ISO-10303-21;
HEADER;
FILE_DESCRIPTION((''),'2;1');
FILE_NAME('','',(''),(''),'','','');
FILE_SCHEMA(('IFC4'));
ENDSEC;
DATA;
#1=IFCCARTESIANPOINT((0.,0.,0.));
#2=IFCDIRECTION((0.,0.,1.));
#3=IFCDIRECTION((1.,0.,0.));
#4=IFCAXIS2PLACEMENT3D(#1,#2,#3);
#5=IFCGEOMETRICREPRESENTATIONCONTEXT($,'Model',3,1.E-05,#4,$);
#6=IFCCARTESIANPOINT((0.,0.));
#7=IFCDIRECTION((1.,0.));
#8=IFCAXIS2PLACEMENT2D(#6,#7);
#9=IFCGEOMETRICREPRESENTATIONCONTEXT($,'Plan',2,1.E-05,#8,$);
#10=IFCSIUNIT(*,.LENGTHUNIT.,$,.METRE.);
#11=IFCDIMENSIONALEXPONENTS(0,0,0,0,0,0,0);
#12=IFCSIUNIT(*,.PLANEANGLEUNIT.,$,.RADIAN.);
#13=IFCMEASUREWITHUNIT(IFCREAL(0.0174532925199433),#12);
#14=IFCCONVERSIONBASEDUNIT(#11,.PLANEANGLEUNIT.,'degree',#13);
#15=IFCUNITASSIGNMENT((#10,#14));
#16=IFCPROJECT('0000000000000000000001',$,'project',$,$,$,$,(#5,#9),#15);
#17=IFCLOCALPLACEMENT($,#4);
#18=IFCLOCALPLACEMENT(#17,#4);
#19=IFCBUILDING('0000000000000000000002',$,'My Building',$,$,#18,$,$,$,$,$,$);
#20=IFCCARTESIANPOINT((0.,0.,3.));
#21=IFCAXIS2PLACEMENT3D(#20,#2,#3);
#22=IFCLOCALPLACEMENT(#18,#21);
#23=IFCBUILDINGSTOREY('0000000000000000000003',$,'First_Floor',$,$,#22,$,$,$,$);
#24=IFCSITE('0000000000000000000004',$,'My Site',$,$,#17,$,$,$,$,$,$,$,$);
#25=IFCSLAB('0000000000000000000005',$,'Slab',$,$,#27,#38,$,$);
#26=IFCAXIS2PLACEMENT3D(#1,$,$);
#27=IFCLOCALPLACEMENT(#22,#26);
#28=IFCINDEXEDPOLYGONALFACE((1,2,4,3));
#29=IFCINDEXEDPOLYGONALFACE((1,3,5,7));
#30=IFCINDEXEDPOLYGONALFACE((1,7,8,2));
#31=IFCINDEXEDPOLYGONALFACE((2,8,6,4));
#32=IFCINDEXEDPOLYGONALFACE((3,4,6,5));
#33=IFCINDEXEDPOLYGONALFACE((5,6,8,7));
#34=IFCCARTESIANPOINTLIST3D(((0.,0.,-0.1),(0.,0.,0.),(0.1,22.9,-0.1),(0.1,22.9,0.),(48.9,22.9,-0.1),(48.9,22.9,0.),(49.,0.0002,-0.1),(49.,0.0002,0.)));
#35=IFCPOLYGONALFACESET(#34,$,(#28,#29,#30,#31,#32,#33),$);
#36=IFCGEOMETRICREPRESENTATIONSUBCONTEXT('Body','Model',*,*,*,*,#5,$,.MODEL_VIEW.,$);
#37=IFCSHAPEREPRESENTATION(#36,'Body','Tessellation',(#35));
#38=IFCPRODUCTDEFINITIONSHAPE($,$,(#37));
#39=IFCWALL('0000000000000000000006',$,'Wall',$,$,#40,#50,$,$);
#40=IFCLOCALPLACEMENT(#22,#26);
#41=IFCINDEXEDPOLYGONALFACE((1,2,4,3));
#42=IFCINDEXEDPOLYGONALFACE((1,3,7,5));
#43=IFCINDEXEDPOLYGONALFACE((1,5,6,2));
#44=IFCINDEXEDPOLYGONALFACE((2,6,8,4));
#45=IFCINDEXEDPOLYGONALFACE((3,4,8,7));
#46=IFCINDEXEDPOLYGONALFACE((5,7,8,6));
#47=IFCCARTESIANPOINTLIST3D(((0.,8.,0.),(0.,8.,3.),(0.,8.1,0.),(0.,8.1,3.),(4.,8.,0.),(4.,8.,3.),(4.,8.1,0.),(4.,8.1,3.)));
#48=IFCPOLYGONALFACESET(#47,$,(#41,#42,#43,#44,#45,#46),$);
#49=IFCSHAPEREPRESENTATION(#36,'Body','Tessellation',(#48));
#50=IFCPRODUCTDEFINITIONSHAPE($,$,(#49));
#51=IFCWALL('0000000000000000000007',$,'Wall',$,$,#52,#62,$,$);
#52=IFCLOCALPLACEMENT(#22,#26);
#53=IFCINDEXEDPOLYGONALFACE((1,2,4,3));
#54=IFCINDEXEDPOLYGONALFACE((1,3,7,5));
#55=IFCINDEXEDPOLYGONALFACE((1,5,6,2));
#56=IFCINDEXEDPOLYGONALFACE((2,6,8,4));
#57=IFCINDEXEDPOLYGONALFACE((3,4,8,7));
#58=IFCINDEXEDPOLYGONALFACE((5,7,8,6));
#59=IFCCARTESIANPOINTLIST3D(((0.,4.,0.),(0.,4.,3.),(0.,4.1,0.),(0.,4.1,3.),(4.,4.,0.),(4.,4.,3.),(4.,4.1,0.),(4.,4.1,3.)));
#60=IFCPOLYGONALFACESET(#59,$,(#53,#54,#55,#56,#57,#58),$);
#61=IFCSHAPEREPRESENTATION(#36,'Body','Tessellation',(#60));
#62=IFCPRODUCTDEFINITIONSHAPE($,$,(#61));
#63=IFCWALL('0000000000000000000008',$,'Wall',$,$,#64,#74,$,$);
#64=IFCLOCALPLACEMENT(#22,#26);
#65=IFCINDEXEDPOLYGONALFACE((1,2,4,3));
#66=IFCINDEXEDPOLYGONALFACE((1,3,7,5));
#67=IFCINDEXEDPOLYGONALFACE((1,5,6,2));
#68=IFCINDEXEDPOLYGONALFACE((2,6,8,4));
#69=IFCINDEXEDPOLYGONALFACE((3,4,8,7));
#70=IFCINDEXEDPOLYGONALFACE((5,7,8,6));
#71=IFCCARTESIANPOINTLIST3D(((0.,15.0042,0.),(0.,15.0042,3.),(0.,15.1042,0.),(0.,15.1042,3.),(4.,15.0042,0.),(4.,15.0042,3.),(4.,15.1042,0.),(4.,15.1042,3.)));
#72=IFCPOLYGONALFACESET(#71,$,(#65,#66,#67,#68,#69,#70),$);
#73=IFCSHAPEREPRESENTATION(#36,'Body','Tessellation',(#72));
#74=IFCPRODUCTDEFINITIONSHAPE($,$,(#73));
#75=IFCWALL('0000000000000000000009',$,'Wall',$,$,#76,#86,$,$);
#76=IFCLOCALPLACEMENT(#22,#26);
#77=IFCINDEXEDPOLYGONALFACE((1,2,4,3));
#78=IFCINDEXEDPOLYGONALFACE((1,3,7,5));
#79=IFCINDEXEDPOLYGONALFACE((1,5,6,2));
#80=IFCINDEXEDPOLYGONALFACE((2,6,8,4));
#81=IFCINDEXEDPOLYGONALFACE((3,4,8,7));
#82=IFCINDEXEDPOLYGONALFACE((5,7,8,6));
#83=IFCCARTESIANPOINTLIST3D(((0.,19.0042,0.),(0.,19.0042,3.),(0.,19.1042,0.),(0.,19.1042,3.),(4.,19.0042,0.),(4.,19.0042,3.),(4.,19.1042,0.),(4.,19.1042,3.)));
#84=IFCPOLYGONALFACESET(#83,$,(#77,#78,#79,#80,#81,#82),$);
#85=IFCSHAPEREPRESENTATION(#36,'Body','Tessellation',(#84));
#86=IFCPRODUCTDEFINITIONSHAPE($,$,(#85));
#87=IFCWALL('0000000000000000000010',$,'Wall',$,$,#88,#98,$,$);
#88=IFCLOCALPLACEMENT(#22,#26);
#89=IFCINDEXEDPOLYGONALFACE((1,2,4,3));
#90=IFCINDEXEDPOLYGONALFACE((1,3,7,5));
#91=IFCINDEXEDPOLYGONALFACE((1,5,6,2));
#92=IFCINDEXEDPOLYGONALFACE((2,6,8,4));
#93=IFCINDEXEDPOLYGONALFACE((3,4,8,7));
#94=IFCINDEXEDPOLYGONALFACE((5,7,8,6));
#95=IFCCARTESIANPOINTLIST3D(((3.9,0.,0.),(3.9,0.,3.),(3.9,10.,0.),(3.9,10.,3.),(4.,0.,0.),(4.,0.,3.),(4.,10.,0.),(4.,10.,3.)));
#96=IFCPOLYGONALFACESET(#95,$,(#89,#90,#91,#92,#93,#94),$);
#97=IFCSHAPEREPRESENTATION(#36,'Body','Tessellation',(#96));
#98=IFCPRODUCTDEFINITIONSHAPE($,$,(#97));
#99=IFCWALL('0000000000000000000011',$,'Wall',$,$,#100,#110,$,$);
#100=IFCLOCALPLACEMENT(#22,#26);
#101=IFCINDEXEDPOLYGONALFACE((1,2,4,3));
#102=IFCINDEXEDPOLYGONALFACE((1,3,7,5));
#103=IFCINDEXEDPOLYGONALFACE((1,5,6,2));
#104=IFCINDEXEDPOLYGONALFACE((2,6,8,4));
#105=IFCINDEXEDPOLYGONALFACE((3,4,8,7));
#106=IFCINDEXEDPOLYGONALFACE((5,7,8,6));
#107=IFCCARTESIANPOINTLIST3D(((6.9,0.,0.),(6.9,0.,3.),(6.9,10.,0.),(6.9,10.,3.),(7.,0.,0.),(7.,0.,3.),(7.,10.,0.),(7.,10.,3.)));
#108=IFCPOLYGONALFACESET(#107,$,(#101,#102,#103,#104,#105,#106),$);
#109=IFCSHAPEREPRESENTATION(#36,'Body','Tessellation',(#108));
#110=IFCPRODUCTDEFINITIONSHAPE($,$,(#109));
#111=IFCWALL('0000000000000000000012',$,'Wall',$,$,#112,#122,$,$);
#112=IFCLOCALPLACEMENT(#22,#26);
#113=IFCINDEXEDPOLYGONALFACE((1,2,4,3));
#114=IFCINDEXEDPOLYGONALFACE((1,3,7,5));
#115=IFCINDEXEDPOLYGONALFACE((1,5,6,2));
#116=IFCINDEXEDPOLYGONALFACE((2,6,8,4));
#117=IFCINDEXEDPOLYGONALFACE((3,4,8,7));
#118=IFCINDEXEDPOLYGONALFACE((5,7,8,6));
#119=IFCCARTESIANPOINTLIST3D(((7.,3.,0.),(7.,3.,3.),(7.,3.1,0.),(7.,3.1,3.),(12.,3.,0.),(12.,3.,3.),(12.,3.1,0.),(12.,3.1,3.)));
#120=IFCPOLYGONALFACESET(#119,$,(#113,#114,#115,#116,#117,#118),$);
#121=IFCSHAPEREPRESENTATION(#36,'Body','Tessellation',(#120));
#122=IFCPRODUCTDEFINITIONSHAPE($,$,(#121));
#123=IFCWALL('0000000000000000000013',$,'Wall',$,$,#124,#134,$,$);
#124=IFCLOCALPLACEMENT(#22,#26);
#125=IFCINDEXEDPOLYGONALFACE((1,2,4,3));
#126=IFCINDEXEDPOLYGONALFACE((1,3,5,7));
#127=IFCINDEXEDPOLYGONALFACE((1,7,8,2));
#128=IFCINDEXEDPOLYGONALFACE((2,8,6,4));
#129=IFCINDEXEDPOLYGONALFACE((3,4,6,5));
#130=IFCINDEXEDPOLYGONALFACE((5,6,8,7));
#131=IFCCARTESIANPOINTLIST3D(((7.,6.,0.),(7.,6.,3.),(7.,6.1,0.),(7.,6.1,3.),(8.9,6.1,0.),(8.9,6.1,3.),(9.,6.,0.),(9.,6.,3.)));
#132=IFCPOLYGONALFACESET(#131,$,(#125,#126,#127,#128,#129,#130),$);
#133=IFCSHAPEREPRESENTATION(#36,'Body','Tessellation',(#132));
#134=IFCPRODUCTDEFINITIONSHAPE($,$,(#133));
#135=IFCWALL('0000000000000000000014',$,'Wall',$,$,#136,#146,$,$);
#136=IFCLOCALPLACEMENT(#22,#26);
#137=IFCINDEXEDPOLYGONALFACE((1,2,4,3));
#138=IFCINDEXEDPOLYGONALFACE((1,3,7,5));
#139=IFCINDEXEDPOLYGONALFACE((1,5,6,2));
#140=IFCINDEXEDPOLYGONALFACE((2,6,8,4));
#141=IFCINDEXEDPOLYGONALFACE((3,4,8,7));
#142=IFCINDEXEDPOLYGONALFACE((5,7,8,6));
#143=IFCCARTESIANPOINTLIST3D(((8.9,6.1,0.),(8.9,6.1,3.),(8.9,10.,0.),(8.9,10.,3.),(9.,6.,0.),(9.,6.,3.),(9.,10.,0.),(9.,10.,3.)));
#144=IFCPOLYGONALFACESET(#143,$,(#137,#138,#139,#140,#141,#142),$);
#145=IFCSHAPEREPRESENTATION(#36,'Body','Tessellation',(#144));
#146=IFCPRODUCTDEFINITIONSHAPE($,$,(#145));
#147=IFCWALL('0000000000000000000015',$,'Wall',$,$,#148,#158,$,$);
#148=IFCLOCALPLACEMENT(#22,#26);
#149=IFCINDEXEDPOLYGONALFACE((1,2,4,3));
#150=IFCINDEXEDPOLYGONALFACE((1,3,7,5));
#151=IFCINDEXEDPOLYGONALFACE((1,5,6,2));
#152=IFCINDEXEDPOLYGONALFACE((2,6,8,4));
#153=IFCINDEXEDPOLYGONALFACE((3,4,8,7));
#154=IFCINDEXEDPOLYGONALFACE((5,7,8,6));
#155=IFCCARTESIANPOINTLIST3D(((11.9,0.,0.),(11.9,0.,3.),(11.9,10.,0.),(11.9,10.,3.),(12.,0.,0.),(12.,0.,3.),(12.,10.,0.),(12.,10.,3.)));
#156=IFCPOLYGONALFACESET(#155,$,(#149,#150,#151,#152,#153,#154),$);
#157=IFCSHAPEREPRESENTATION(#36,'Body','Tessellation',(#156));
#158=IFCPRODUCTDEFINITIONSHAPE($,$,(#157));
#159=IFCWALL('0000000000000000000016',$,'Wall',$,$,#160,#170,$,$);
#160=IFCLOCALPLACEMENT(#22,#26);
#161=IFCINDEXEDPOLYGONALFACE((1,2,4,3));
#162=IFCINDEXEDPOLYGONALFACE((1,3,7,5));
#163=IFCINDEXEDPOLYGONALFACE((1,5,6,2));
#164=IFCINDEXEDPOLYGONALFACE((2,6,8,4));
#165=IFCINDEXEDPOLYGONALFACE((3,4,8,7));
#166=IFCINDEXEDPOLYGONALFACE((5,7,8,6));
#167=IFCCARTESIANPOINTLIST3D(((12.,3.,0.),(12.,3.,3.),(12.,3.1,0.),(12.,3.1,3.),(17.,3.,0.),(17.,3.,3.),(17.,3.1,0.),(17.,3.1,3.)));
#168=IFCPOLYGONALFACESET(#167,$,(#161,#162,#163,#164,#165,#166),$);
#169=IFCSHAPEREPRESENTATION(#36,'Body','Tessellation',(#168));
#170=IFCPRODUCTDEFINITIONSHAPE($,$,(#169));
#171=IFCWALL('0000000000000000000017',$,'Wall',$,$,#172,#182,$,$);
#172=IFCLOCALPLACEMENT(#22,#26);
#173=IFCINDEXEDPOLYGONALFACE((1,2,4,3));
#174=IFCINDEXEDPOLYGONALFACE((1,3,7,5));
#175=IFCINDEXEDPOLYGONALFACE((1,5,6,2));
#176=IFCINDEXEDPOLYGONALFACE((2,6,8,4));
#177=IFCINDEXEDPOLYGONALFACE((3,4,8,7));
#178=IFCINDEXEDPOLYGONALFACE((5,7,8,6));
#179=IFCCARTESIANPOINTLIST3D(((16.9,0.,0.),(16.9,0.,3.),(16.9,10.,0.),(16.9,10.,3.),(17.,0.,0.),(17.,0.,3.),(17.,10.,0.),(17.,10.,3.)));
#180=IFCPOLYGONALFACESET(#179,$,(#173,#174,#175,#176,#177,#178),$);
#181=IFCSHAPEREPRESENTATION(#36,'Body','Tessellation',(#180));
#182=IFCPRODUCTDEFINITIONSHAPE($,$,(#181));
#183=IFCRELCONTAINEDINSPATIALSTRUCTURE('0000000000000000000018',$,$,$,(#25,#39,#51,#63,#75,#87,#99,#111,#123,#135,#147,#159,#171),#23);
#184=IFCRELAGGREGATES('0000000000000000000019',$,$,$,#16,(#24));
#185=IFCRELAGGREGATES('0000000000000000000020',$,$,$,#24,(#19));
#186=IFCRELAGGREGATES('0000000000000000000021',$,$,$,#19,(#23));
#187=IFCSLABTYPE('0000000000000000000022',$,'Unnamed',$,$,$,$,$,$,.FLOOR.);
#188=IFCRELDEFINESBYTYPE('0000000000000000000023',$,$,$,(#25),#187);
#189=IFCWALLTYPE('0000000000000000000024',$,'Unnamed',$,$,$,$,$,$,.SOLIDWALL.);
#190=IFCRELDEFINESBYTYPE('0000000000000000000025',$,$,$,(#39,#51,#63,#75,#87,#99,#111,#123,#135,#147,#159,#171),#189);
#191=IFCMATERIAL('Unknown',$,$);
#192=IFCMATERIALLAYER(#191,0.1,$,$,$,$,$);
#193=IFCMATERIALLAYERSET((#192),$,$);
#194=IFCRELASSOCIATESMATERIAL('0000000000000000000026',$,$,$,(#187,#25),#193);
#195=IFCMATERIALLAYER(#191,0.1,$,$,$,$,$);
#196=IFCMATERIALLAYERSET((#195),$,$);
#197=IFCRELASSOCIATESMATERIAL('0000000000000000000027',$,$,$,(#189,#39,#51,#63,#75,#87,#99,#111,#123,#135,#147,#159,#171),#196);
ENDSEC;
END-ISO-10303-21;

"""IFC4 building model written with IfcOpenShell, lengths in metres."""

from ifc_helpers import new_model, entity, si_unit, converted_unit, frame, origin_with_axes, origin_2d_with_axis, place, context, subcontext, project, spatial, line, indexed_curve, outline, extrude, material, layer, layer_set, layer_usage, type_object, element, save


model = new_model("IFC4")

# Units and contexts
model_context = context("Model", 3, precision=1e-05, world=origin_with_axes())
plan_context = context("Plan", 2, precision=1e-05, world=origin_2d_with_axis())
body_context = subcontext(model_context, "Body", "Model", "MODEL_VIEW")
ifc_project = project(units=[si_unit("LENGTHUNIT", "METRE"), converted_unit("PLANEANGLEUNIT", "degree", entity("IfcReal", 0.0174532925199433), si_unit("PLANEANGLEUNIT", "RADIAN"), dimensions=[0, 0, 0, 0, 0, 0, 0])], contexts=[model_context, plan_context])

# Site, building, storey
site_placement = place(None, origin_with_axes())
site = spatial("IfcSite", under=ifc_project, at=site_placement, Name="My Site")
building_placement = place(site_placement, origin_with_axes())
building = spatial("IfcBuilding", under=site, at=building_placement, Name="My Building")
storey_placement = place(building_placement, frame((0.0, 0.0, 3.0), z_axis=(0.0, 0.0, 1.0), x_axis=(1.0, 0.0, 0.0)))
storey = spatial("IfcBuildingStorey", under=building, at=storey_placement, Name="First_Floor")

# Slab
ifc_material = material(Name="Unknown")
ifc_layer_1 = layer(ifc_material, 0.1)
ifc_layer_set_1 = layer_set([ifc_layer_1])
ifc_layer_usage_1 = layer_usage(ifc_layer_set_1, "AXIS3", "POSITIVE", -0.1)
slab_type = type_object("IfcSlabType", Name="Unnamed", PredefinedType="FLOOR", material=ifc_layer_set_1)
slab_placement = place(storey_placement, frame((0.1, 22.9, 0.0), z_axis=(0.0, 0.0, 1.0), x_axis=(1.0, 0.0, 0.0)))
element("IfcSlab", 1, at=slab_placement, inside=storey, type_object=slab_type, material=ifc_layer_usage_1, Name="Slab", context=body_context, shape_type="SweptSolid", body=[
    extrude(outline(indexed_curve([(0.0, 0.0), (48.8, 0.0), (48.9, -22.8998), (-0.1, -22.9), (0.0, 0.0)])), frame((0.0, 0.0, -0.1), z_axis=(0.0, 0.0, 1.0), x_axis=(1.0, 0.0, 0.0)), (0.0, 0.0, 1.0), 0.1),
])

# Walls
ifc_layer_2 = layer(ifc_material, 0.1)
ifc_layer_set_2 = layer_set([ifc_layer_2])
ifc_layer_usage_2 = layer_usage(ifc_layer_set_2, "AXIS2", "POSITIVE", 0.0)
wall_type = type_object("IfcWallType", Name="Unnamed", PredefinedType="SOLIDWALL", material=ifc_layer_set_2)
wall_1_placement = place(storey_placement, frame((0.0, 8.0, 0.0), z_axis=(0.0, 0.0, 1.0), x_axis=(1.0, 0.0, 0.0)))
element("IfcWall", 2, at=wall_1_placement, inside=storey, type_object=wall_type, material=ifc_layer_usage_2, Name="Wall", context=body_context, shape_type="SweptSolid", body=[
    extrude(outline(indexed_curve([(0.0, 0.0), (0.0, 0.1), (4.0, 0.1), (4.0, 0.0)], segments=[line(1, 2, 3, 4, 1)])), origin_with_axes(), (0.0, 0.0, 1.0), 3.0),
])
ifc_layer_usage_3 = layer_usage(ifc_layer_set_2, "AXIS2", "POSITIVE", 0.0)
wall_2_placement = place(storey_placement, frame((0.0, 4.0, 0.0), z_axis=(0.0, 0.0, 1.0), x_axis=(1.0, 0.0, 0.0)))
element("IfcWall", 3, at=wall_2_placement, inside=storey, type_object=wall_type, material=ifc_layer_usage_3, Name="Wall", context=body_context, shape_type="SweptSolid", body=[
    extrude(outline(indexed_curve([(0.0, 0.0), (0.0, 0.1), (4.0, 0.1), (4.0, 0.0)], segments=[line(1, 2, 3, 4, 1)])), origin_with_axes(), (0.0, 0.0, 1.0), 3.0),
])
ifc_layer_usage_4 = layer_usage(ifc_layer_set_2, "AXIS2", "POSITIVE", 0.0)
wall_3_placement = place(storey_placement, frame((0.0, 15.0042, 0.0), z_axis=(0.0, 0.0, 1.0), x_axis=(1.0, 0.0, 0.0)))
element("IfcWall", 4, at=wall_3_placement, inside=storey, type_object=wall_type, material=ifc_layer_usage_4, Name="Wall", context=body_context, shape_type="SweptSolid", body=[
    extrude(outline(indexed_curve([(0.0, 0.0), (0.0, 0.1), (4.0, 0.1), (4.0, 0.0)], segments=[line(1, 2, 3, 4, 1)])), origin_with_axes(), (0.0, 0.0, 1.0), 3.0),
])
ifc_layer_usage_5 = layer_usage(ifc_layer_set_2, "AXIS2", "POSITIVE", 0.0)
wall_4_placement = place(storey_placement, frame((0.0, 19.0042, 0.0), z_axis=(0.0, 0.0, 1.0), x_axis=(1.0, 0.0, 0.0)))
element("IfcWall", 5, at=wall_4_placement, inside=storey, type_object=wall_type, material=ifc_layer_usage_5, Name="Wall", context=body_context, shape_type="SweptSolid", body=[
    extrude(outline(indexed_curve([(0.0, 0.0), (0.0, 0.1), (4.0, 0.1), (4.0, 0.0)], segments=[line(1, 2, 3, 4, 1)])), origin_with_axes(), (0.0, 0.0, 1.0), 3.0),
])
ifc_layer_usage_6 = layer_usage(ifc_layer_set_2, "AXIS2", "POSITIVE", 0.0)
wall_5_placement = place(storey_placement, frame((3.9, 10.0, 0.0), z_axis=(0.0, 0.0, 1.0), x_axis=(0.0, -1.0, 0.0)))
element("IfcWall", 6, at=wall_5_placement, inside=storey, type_object=wall_type, material=ifc_layer_usage_6, Name="Wall", context=body_context, shape_type="SweptSolid", body=[
    extrude(outline(indexed_curve([(0.0, 0.0), (0.0, 0.1), (10.0, 0.1), (10.0, 0.0)], segments=[line(1, 2, 3, 4, 1)])), origin_with_axes(), (0.0, 0.0, 1.0), 3.0),
])
ifc_layer_usage_7 = layer_usage(ifc_layer_set_2, "AXIS2", "POSITIVE", 0.0)
wall_6_placement = place(storey_placement, frame((6.9, 10.0, 0.0), z_axis=(0.0, 0.0, 1.0), x_axis=(0.0, -1.0, 0.0)))
element("IfcWall", 7, at=wall_6_placement, inside=storey, type_object=wall_type, material=ifc_layer_usage_7, Name="Wall", context=body_context, shape_type="SweptSolid", body=[
    extrude(outline(indexed_curve([(0.0, 0.0), (0.0, 0.1), (10.0, 0.1), (10.0, 0.0)], segments=[line(1, 2, 3, 4, 1)])), origin_with_axes(), (0.0, 0.0, 1.0), 3.0),
])
ifc_layer_usage_8 = layer_usage(ifc_layer_set_2, "AXIS2", "POSITIVE", 0.0)
wall_7_placement = place(storey_placement, frame((7.0, 3.0, 0.0), z_axis=(0.0, 0.0, 1.0), x_axis=(1.0, 0.0, 0.0)))
element("IfcWall", 8, at=wall_7_placement, inside=storey, type_object=wall_type, material=ifc_layer_usage_8, Name="Wall", context=body_context, shape_type="SweptSolid", body=[
    extrude(outline(indexed_curve([(0.0, 0.0), (0.0, 0.1), (5.0, 0.1), (5.0, 0.0)], segments=[line(1, 2, 3, 4, 1)])), origin_with_axes(), (0.0, 0.0, 1.0), 3.0),
])
ifc_layer_usage_9 = layer_usage(ifc_layer_set_2, "AXIS2", "POSITIVE", 0.0)
wall_8_placement = place(storey_placement, frame((7.0, 6.0, 0.0), z_axis=(0.0, 0.0, 1.0), x_axis=(1.0, 0.0, 0.0)))
element("IfcWall", 9, at=wall_8_placement, inside=storey, type_object=wall_type, material=ifc_layer_usage_9, Name="Wall", context=body_context, shape_type="SweptSolid", body=[
    extrude(outline(indexed_curve([(0.0, 0.0), (0.0, 0.1), (1.9, 0.1), (2.0, 0.0)], segments=[line(1, 2, 3, 4, 1)])), origin_with_axes(), (0.0, 0.0, 1.0), 3.0),
])
ifc_layer_usage_10 = layer_usage(ifc_layer_set_2, "AXIS2", "POSITIVE", 0.0)
wall_9_placement = place(storey_placement, frame((9.0, 6.0, 0.0), z_axis=(0.0, 0.0, 1.0), x_axis=(0.0, 1.0, 0.0)))
element("IfcWall", 10, at=wall_9_placement, inside=storey, type_object=wall_type, material=ifc_layer_usage_10, Name="Wall", context=body_context, shape_type="SweptSolid", body=[
    extrude(outline(indexed_curve([(0.0, 0.0), (0.1, 0.1), (4.0, 0.1), (4.0, 0.0)], segments=[line(1, 2, 3, 4, 1)])), origin_with_axes(), (0.0, 0.0, 1.0), 3.0),
])
ifc_layer_usage_11 = layer_usage(ifc_layer_set_2, "AXIS2", "POSITIVE", 0.0)
wall_10_placement = place(storey_placement, frame((11.9, 10.0, 0.0), z_axis=(0.0, 0.0, 1.0), x_axis=(0.0, -1.0, 0.0)))
element("IfcWall", 11, at=wall_10_placement, inside=storey, type_object=wall_type, material=ifc_layer_usage_11, Name="Wall", context=body_context, shape_type="SweptSolid", body=[
    extrude(outline(indexed_curve([(0.0, 0.0), (0.0, 0.1), (10.0, 0.1), (10.0, 0.0)], segments=[line(1, 2, 3, 4, 1)])), origin_with_axes(), (0.0, 0.0, 1.0), 3.0),
])
ifc_layer_usage_12 = layer_usage(ifc_layer_set_2, "AXIS2", "POSITIVE", 0.0)
wall_11_placement = place(storey_placement, frame((12.0, 3.0, 0.0), z_axis=(0.0, 0.0, 1.0), x_axis=(1.0, 0.0, 0.0)))
element("IfcWall", 12, at=wall_11_placement, inside=storey, type_object=wall_type, material=ifc_layer_usage_12, Name="Wall", context=body_context, shape_type="SweptSolid", body=[
    extrude(outline(indexed_curve([(0.0, 0.0), (0.0, 0.1), (5.0, 0.1), (5.0, 0.0)], segments=[line(1, 2, 3, 4, 1)])), origin_with_axes(), (0.0, 0.0, 1.0), 3.0),
])
ifc_layer_usage_13 = layer_usage(ifc_layer_set_2, "AXIS2", "POSITIVE", 0.0)
wall_12_placement = place(storey_placement, frame((16.9, 10.0, 0.0), z_axis=(0.0, 0.0, 1.0), x_axis=(0.0, -1.0, 0.0)))
element("IfcWall", 13, at=wall_12_placement, inside=storey, type_object=wall_type, material=ifc_layer_usage_13, Name="Wall", context=body_context, shape_type="SweptSolid", body=[
    extrude(outline(indexed_curve([(0.0, 0.0), (0.0, 0.1), (10.0, 0.1), (10.0, 0.0)], segments=[line(1, 2, 3, 4, 1)])), origin_with_axes(), (0.0, 0.0, 1.0), 3.0),
])

save(model, "model.ifc")
